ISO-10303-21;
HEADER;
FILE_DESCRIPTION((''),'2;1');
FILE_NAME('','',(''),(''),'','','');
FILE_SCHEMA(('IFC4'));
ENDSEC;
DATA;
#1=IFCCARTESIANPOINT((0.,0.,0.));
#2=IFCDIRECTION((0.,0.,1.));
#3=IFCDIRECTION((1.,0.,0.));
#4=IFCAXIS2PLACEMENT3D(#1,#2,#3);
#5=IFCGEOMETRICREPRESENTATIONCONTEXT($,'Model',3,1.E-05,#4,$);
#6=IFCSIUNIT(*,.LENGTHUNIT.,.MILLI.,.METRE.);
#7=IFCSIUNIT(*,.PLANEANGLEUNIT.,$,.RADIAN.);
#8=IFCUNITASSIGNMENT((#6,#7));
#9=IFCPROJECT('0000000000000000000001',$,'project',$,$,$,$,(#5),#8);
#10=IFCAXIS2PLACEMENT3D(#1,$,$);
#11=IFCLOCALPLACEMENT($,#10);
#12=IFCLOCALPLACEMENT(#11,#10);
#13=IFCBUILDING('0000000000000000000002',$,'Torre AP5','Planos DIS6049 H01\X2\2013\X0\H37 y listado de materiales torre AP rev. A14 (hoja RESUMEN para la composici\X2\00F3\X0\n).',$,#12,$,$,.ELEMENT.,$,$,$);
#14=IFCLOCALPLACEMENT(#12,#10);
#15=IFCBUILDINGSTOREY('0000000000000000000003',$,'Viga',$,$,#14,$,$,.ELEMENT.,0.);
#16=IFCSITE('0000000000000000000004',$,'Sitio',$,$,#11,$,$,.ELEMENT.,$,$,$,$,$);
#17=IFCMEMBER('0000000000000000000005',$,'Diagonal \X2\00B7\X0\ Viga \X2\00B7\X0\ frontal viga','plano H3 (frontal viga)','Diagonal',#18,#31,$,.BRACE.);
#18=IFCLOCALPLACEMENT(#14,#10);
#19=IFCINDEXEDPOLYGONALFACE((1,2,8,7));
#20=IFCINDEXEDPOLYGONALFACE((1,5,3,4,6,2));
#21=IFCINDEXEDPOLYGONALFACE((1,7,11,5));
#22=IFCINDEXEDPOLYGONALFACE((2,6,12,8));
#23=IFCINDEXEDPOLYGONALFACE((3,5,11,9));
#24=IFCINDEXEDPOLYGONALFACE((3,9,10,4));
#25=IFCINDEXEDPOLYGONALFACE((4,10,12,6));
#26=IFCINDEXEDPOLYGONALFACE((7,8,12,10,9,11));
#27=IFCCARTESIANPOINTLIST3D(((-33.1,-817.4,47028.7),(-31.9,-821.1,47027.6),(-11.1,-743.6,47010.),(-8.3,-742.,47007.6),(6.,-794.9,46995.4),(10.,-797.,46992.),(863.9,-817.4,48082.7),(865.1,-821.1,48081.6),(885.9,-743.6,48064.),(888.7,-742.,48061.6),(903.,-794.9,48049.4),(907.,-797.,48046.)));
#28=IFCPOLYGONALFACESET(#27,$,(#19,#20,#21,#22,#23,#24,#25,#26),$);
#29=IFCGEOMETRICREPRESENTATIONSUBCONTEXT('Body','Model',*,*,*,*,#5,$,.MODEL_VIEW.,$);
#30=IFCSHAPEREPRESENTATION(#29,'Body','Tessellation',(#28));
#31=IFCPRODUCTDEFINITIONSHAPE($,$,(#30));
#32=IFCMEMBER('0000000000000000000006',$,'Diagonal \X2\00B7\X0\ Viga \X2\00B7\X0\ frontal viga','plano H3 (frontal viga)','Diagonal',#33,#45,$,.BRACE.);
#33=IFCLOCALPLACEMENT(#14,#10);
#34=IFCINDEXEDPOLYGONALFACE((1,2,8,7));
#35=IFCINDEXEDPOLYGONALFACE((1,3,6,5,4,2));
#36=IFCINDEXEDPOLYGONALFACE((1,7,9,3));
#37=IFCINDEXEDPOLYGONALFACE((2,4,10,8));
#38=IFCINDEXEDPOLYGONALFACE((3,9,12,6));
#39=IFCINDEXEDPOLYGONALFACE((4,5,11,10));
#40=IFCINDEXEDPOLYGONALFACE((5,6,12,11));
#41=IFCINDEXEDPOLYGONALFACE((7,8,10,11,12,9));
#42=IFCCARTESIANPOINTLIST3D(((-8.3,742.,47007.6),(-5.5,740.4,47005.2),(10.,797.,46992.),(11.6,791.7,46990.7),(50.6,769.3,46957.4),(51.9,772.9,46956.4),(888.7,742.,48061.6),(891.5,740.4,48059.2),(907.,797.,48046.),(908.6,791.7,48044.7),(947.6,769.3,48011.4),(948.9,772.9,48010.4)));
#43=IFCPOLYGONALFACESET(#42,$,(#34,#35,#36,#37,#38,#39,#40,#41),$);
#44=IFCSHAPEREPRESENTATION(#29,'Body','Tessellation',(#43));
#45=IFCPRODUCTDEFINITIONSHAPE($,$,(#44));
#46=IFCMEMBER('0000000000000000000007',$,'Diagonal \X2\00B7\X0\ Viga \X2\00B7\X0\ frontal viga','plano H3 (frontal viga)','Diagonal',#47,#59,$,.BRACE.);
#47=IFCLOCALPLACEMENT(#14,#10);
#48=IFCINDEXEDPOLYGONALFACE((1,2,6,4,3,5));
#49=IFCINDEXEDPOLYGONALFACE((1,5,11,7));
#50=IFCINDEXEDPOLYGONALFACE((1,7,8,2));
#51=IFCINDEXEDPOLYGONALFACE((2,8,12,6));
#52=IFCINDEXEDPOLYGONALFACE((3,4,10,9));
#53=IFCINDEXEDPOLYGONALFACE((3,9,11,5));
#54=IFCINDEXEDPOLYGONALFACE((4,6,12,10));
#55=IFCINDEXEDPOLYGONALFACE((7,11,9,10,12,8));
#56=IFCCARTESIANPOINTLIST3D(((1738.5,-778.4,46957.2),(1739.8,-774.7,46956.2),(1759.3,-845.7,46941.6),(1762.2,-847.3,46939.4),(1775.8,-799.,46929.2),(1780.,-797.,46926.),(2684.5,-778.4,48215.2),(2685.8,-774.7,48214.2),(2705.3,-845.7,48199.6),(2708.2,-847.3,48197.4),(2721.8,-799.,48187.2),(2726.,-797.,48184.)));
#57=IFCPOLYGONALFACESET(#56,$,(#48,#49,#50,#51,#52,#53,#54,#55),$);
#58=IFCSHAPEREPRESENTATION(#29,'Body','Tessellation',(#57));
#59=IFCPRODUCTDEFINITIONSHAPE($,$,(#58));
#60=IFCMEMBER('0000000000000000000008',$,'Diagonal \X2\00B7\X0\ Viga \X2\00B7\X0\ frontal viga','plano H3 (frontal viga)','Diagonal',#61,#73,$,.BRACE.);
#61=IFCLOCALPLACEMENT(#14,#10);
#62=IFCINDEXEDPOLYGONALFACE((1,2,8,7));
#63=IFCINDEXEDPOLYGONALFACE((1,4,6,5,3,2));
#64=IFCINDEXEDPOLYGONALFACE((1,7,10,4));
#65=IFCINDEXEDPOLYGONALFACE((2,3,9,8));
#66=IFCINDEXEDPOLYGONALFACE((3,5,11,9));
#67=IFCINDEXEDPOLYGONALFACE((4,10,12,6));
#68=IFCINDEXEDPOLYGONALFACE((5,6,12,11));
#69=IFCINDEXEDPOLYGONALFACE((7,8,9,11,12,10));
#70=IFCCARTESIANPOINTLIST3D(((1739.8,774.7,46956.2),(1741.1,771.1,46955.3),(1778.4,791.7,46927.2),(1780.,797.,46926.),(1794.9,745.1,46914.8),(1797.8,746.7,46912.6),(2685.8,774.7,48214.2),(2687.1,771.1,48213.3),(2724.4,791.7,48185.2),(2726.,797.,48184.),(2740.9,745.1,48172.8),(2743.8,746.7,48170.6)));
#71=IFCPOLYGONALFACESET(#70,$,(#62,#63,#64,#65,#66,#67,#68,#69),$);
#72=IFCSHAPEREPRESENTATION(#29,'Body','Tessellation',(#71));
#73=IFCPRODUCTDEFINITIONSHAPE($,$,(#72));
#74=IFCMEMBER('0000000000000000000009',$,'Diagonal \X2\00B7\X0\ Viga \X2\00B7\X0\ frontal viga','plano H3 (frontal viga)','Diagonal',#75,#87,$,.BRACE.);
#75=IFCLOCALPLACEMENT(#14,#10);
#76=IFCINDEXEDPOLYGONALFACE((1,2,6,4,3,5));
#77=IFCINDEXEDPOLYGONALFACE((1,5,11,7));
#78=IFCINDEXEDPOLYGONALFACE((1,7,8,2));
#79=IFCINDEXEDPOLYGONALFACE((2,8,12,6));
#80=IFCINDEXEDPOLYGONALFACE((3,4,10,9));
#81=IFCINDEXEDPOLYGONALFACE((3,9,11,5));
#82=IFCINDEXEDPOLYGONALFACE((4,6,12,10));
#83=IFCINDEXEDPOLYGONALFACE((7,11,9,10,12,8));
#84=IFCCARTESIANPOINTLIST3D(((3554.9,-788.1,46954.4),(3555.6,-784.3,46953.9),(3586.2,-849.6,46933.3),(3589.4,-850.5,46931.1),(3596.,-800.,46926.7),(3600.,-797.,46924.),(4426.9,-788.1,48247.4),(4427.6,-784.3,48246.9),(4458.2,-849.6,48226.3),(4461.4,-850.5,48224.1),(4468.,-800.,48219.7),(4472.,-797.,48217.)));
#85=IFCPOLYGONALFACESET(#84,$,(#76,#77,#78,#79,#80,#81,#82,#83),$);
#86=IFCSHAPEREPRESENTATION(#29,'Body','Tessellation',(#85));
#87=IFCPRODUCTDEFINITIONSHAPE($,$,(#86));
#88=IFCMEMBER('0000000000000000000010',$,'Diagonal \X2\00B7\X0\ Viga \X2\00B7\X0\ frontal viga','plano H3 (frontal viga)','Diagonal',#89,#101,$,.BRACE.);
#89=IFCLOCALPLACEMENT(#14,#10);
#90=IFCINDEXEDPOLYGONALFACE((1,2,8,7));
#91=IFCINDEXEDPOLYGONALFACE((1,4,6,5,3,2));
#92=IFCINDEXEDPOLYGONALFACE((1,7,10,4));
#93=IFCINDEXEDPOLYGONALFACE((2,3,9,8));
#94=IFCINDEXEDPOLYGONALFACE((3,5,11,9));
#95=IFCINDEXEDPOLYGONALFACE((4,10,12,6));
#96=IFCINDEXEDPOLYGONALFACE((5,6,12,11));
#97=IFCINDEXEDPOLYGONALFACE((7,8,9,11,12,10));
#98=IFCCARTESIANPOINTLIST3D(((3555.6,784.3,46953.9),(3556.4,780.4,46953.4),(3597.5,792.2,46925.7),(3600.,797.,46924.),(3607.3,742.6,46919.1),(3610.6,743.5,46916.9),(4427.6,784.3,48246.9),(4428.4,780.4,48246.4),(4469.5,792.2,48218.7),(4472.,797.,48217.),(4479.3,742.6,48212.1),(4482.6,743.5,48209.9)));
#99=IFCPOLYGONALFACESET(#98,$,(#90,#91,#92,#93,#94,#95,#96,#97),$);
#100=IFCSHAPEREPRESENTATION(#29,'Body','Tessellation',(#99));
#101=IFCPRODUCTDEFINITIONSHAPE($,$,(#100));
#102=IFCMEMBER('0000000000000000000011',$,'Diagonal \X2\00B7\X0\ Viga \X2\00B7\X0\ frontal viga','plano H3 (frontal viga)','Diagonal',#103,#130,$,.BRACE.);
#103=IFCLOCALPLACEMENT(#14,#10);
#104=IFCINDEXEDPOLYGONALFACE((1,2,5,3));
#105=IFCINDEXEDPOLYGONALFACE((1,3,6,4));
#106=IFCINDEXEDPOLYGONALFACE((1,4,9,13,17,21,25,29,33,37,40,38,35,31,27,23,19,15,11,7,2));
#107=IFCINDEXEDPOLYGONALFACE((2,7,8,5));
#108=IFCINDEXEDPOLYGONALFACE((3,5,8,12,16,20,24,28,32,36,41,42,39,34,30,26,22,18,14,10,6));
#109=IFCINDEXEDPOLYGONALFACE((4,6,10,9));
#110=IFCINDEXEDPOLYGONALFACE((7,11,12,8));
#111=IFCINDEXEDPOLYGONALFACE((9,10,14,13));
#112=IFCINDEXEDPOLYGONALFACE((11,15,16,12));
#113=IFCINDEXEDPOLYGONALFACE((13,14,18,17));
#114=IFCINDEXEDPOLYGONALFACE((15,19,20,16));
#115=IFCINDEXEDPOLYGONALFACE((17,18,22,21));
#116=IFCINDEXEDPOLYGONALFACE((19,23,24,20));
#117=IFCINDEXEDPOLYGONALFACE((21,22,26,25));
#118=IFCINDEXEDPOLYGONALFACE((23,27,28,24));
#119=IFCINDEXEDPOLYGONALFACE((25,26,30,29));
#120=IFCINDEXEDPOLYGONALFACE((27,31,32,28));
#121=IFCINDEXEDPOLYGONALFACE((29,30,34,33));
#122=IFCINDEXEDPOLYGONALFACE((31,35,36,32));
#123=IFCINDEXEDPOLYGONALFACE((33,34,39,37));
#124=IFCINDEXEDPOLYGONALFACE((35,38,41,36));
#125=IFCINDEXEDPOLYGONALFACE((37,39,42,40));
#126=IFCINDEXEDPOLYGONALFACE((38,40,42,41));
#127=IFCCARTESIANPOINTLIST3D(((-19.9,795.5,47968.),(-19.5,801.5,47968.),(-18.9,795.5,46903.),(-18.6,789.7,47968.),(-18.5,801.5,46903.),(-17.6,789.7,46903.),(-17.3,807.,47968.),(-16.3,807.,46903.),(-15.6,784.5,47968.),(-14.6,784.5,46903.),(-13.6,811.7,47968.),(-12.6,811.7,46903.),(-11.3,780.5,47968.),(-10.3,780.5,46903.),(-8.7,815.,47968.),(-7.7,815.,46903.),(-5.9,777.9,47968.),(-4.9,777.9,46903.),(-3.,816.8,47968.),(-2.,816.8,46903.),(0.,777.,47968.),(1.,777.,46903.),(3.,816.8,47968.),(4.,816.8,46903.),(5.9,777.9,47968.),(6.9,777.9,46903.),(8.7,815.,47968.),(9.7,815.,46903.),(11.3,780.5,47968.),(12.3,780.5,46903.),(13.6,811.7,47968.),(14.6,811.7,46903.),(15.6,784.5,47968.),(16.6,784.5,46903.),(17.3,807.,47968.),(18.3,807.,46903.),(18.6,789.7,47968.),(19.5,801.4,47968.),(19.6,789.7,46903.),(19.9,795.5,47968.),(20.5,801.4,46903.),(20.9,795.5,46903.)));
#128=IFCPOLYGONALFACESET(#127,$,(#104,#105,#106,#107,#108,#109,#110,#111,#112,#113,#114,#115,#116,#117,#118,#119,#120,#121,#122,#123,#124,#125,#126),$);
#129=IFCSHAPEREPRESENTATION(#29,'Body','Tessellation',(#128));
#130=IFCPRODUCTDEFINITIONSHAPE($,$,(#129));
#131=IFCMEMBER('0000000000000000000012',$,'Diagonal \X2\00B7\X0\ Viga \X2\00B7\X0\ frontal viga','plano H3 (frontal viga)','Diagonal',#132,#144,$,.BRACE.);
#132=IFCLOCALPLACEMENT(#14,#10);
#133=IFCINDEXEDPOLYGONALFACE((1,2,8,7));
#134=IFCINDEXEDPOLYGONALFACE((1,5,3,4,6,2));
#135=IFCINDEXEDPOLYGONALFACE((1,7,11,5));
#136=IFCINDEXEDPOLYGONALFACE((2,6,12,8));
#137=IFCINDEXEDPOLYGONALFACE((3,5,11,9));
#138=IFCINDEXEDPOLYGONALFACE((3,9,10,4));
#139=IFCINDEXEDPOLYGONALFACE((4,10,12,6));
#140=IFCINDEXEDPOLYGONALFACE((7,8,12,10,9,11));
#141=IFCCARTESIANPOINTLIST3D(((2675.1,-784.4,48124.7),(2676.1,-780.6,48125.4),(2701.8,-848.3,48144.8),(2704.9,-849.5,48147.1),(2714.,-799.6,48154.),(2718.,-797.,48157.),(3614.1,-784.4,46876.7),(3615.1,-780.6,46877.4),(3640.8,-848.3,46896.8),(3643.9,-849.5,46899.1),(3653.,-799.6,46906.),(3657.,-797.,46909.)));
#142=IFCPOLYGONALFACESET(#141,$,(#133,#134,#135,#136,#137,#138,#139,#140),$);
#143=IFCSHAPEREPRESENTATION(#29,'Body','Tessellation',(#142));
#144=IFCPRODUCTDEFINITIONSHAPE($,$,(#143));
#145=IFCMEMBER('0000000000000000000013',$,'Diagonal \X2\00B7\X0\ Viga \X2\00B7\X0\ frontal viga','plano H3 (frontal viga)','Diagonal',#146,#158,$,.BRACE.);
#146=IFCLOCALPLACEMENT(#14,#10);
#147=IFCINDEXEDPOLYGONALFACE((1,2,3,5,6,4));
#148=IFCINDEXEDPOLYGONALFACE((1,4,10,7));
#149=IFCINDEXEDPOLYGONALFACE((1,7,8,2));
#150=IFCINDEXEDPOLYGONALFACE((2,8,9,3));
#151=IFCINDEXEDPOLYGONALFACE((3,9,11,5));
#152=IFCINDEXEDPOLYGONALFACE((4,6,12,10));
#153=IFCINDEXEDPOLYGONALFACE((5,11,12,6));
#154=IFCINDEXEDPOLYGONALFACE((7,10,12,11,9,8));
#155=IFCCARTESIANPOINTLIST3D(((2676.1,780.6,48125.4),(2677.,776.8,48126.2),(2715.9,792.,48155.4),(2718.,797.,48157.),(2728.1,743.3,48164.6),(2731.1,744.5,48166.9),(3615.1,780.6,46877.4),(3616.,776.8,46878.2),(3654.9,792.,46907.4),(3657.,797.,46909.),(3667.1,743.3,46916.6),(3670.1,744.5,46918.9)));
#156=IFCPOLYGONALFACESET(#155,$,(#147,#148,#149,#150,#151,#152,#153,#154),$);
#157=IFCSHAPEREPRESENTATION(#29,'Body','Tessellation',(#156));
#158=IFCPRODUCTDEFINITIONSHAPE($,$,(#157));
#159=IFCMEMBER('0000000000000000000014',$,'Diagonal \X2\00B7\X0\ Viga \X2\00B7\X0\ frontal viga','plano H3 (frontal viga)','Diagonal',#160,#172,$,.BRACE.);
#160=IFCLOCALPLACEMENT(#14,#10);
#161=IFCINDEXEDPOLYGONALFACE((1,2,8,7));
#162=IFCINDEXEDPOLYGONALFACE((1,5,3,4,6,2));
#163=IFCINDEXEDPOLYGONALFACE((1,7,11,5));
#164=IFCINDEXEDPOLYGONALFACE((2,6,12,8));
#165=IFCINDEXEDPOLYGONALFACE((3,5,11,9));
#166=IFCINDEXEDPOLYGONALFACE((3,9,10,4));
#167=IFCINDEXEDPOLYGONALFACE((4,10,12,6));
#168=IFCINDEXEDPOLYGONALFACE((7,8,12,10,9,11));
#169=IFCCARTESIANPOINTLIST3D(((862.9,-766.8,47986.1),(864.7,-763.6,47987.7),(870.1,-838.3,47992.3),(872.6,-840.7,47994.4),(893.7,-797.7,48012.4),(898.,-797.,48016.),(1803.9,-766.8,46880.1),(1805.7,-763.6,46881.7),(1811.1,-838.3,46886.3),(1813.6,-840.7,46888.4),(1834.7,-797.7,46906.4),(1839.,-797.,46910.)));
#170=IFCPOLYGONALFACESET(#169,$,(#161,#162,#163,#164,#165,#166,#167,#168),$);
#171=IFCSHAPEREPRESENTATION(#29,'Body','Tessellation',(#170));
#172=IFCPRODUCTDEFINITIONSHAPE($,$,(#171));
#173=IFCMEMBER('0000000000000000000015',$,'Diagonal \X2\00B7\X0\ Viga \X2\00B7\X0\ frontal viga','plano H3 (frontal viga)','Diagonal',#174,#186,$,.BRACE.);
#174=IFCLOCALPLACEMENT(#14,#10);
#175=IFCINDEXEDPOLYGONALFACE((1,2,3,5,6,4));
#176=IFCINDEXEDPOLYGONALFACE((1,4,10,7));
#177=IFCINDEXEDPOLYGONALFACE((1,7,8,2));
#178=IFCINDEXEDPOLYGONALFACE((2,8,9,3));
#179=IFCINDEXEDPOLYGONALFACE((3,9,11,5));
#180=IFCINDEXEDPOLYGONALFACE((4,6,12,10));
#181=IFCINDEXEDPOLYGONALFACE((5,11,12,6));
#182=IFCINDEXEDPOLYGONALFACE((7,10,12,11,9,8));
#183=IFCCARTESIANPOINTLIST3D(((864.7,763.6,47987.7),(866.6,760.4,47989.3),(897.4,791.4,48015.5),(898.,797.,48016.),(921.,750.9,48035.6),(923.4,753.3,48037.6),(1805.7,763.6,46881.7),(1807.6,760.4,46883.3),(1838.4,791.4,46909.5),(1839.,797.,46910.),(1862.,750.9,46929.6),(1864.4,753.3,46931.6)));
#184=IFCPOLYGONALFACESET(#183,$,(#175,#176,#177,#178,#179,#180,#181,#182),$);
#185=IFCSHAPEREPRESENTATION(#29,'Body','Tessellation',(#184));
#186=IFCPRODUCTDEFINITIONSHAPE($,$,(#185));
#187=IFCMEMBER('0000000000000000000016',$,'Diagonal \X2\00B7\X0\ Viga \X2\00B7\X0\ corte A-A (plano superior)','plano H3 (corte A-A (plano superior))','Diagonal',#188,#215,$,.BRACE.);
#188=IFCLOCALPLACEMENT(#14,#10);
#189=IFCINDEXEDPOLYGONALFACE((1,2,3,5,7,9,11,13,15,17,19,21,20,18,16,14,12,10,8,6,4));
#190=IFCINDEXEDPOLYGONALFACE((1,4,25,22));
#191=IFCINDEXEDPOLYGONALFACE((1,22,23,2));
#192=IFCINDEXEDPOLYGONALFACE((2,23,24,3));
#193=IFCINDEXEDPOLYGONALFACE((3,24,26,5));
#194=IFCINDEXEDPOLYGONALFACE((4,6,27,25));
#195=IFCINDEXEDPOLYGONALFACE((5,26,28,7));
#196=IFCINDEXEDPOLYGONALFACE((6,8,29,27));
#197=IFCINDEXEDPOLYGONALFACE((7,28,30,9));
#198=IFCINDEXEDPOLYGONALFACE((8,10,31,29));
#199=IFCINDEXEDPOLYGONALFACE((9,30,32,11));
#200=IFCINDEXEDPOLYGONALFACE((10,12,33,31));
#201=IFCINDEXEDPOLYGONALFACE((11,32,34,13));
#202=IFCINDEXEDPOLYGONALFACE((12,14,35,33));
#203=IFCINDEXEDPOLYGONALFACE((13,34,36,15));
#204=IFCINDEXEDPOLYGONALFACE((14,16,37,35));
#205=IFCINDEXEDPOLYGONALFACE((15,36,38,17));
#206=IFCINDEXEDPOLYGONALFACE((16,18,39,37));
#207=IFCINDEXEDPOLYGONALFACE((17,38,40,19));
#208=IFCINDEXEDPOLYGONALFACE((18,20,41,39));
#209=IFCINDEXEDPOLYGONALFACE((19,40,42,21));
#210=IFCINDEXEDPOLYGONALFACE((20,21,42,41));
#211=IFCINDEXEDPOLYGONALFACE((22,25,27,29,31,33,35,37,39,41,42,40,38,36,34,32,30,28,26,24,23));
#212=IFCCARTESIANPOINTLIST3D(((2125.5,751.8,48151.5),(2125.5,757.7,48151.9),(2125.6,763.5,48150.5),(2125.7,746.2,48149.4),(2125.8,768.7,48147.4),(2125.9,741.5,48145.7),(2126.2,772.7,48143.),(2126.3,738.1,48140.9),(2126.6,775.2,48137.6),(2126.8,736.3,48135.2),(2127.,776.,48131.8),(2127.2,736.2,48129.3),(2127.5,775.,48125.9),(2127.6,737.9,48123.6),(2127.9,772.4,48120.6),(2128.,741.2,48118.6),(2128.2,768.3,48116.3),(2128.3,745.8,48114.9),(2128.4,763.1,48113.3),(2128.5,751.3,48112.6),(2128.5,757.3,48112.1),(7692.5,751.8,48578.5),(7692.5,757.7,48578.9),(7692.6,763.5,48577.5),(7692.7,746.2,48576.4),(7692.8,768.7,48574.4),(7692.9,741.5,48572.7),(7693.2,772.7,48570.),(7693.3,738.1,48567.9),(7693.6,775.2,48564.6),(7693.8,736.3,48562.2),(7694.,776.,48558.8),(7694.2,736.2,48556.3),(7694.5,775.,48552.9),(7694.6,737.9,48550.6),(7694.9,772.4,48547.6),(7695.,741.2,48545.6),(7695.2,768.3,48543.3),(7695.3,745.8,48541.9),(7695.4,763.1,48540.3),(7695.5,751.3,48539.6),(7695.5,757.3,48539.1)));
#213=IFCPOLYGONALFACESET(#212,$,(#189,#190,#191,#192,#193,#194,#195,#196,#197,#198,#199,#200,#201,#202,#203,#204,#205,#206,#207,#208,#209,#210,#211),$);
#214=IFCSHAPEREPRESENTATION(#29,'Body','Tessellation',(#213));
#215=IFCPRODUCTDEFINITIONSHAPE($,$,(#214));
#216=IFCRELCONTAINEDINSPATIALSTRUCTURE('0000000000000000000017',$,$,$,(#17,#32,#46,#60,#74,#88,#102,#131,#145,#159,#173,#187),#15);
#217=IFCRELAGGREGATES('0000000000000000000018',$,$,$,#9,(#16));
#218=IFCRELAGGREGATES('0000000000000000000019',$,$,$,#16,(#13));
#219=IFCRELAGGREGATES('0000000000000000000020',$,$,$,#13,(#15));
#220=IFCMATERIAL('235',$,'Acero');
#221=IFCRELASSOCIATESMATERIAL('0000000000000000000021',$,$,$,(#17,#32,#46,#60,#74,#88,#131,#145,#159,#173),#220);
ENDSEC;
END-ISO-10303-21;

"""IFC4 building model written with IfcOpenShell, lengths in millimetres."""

from ifc_helpers import new_model, si_unit, frame, frame_2d, origin, origin_with_axes, place, context, subcontext, project, spatial, circle, l_section, extrude, material, element, save


model = new_model("IFC4")

# Units and contexts
model_context = context("Model", 3, precision=1e-05, world=origin_with_axes())
body_context = subcontext(model_context, "Body", "Model", "MODEL_VIEW")
ifc_project = project(units=[si_unit("LENGTHUNIT", "METRE", prefix="MILLI"), si_unit("PLANEANGLEUNIT", "RADIAN")], contexts=[model_context])

# Site, building, storey
site_placement = place(None, origin())
site = spatial("IfcSite", under=ifc_project, at=site_placement, Name="Sitio", CompositionType="ELEMENT")
building_placement = place(site_placement, origin())
building = spatial("IfcBuilding", under=site, at=building_placement, Name="Torre AP5", Description="Planos DIS6049 H01–H37 y listado de materiales torre AP rev. A14 (hoja RESUMEN para la composición).", CompositionType="ELEMENT")
storey_placement = place(building_placement, origin())
storey = spatial("IfcBuildingStorey", under=building, at=storey_placement, Name="Viga", CompositionType="ELEMENT", Elevation=0.0)

# Members
ifc_material = material(Name="235", Category="Acero")
for number, where, z_axis, x_axis, name in (
    (1, (10.0, -797.0, 46992.0), (0.64811, 0.0, 0.761547), (-0.305596, 0.915954, 0.260076), "Diagonal · Viga · frontal viga"),
    (2, (10.0, 797.0, 46992.0), (0.64811, 0.0, 0.761547), (-0.305596, -0.915954, 0.260076), "Diagonal · Viga · frontal viga"),
):
    element("IfcMember", number, at=place(storey_placement, frame(where, z_axis=z_axis, x_axis=x_axis)), inside=storey, material=ifc_material, Name=name, Description="plano H3 (frontal viga)", ObjectType="Diagonal", PredefinedType="BRACE", context=body_context, shape_type="SweptSolid", body=[
        extrude(l_section(Depth=60.0, Width=60.0, Thickness=4.0, at=frame_2d((30.0, 30.0))), None, (0.0, 0.0, 1.0), 1384.0),
    ])
for number, where, z_axis, x_axis, name in (
    (3, (1780.0, -797.0, 46926.0), (0.601016, 0.0, 0.799237), (-0.730849, 0.404737, 0.549589), "Diagonal · Viga · frontal viga"),
    (4, (1780.0, 797.0, 46926.0), (0.601016, 0.0, 0.799237), (-0.730849, -0.404737, 0.549589), "Diagonal · Viga · frontal viga"),
):
    element("IfcMember", number, at=place(storey_placement, frame(where, z_axis=z_axis, x_axis=x_axis)), inside=storey, material=ifc_material, Name=name, Description="plano H3 (frontal viga)", ObjectType="Diagonal", PredefinedType="BRACE", context=body_context, shape_type="SweptSolid", body=[
        extrude(l_section(Depth=55.0, Width=55.0, Thickness=4.0, at=frame_2d((27.5, 27.5))), None, (0.0, 0.0, 1.0), 1574.0),
    ])
for number, where, z_axis, x_axis, name in (
    (5, (3600.0, -797.0, 46924.0), (0.559131, 0.0, 0.829079), (-0.806517, 0.231702, 0.543916), "Diagonal · Viga · frontal viga"),
    (6, (3600.0, 797.0, 46924.0), (0.559131, 0.0, 0.829079), (-0.806517, -0.231702, 0.543916), "Diagonal · Viga · frontal viga"),
):
    element("IfcMember", number, at=place(storey_placement, frame(where, z_axis=z_axis, x_axis=x_axis)), inside=storey, material=ifc_material, Name=name, Description="plano H3 (frontal viga)", ObjectType="Diagonal", PredefinedType="BRACE", context=body_context, shape_type="SweptSolid", body=[
        extrude(l_section(Depth=55.0, Width=55.0, Thickness=4.0, at=frame_2d((27.5, 27.5))), None, (0.0, 0.0, 1.0), 1559.6),
    ])
member_1_placement = place(storey_placement, frame((1.0, 797.0, 46903.0), z_axis=(-0.000939, 0.0, 1.0), x_axis=(-0.000627, -1.0, -0.000001)))
element("IfcMember", 7, at=member_1_placement, inside=storey, Name="Diagonal · Viga · frontal viga", Description="plano H3 (frontal viga)", ObjectType="Diagonal", PredefinedType="BRACE", context=body_context, shape_type="SweptSolid", body=[
    extrude(circle(Radius=20.0), None, (0.0, 0.0, 1.0), 1065.0),
])
for number, where, z_axis, x_axis, name in (
    (8, (3657.0, -797.0, 46909.0), (-0.601229, 0.0, 0.799077), (-0.762614, 0.298631, -0.573794), "Diagonal · Viga · frontal viga"),
    (9, (3657.0, 797.0, 46909.0), (-0.601229, 0.0, 0.799077), (-0.762614, -0.298631, -0.573794), "Diagonal · Viga · frontal viga"),
):
    element("IfcMember", number, at=place(storey_placement, frame(where, z_axis=z_axis, x_axis=x_axis)), inside=storey, material=ifc_material, Name=name, Description="plano H3 (frontal viga)", ObjectType="Diagonal", PredefinedType="BRACE", context=body_context, shape_type="SweptSolid", body=[
        extrude(l_section(Depth=55.0, Width=55.0, Thickness=4.0, at=frame_2d((27.5, 27.5))), None, (0.0, 0.0, 1.0), 1561.8),
    ])
for number, where, z_axis, x_axis, name in (
    (10, (1839.0, -797.0, 46910.0), (-0.648008, 0.0, 0.761633), (-0.605023, 0.607426, -0.514762), "Diagonal · Viga · frontal viga"),
    (11, (1839.0, 797.0, 46910.0), (-0.648008, 0.0, 0.761633), (-0.605023, -0.607426, -0.514762), "Diagonal · Viga · frontal viga"),
):
    element("IfcMember", number, at=place(storey_placement, frame(where, z_axis=z_axis, x_axis=x_axis)), inside=storey, material=ifc_material, Name=name, Description="plano H3 (frontal viga)", ObjectType="Diagonal", PredefinedType="BRACE", context=body_context, shape_type="SweptSolid", body=[
        extrude(l_section(Depth=55.0, Width=55.0, Thickness=4.0, at=frame_2d((27.5, 27.5))), None, (0.0, 0.0, 1.0), 1452.1),
    ])
member_2_placement = place(storey_placement, frame((2127.0, 756.0, 48132.0), z_axis=(0.997071, 0.0, 0.076477), x_axis=(-0.034023, -0.895589, 0.44358)))
element("IfcMember", 12, at=member_2_placement, inside=storey, Name="Diagonal · Viga · corte A-A (plano superior)", Description="plano H3 (corte A-A (plano superior))", ObjectType="Diagonal", PredefinedType="BRACE", context=body_context, shape_type="SweptSolid", body=[
    extrude(circle(Radius=20.0), None, (0.0, 0.0, 1.0), 5583.4),
])

save(model, "model.ifc")
